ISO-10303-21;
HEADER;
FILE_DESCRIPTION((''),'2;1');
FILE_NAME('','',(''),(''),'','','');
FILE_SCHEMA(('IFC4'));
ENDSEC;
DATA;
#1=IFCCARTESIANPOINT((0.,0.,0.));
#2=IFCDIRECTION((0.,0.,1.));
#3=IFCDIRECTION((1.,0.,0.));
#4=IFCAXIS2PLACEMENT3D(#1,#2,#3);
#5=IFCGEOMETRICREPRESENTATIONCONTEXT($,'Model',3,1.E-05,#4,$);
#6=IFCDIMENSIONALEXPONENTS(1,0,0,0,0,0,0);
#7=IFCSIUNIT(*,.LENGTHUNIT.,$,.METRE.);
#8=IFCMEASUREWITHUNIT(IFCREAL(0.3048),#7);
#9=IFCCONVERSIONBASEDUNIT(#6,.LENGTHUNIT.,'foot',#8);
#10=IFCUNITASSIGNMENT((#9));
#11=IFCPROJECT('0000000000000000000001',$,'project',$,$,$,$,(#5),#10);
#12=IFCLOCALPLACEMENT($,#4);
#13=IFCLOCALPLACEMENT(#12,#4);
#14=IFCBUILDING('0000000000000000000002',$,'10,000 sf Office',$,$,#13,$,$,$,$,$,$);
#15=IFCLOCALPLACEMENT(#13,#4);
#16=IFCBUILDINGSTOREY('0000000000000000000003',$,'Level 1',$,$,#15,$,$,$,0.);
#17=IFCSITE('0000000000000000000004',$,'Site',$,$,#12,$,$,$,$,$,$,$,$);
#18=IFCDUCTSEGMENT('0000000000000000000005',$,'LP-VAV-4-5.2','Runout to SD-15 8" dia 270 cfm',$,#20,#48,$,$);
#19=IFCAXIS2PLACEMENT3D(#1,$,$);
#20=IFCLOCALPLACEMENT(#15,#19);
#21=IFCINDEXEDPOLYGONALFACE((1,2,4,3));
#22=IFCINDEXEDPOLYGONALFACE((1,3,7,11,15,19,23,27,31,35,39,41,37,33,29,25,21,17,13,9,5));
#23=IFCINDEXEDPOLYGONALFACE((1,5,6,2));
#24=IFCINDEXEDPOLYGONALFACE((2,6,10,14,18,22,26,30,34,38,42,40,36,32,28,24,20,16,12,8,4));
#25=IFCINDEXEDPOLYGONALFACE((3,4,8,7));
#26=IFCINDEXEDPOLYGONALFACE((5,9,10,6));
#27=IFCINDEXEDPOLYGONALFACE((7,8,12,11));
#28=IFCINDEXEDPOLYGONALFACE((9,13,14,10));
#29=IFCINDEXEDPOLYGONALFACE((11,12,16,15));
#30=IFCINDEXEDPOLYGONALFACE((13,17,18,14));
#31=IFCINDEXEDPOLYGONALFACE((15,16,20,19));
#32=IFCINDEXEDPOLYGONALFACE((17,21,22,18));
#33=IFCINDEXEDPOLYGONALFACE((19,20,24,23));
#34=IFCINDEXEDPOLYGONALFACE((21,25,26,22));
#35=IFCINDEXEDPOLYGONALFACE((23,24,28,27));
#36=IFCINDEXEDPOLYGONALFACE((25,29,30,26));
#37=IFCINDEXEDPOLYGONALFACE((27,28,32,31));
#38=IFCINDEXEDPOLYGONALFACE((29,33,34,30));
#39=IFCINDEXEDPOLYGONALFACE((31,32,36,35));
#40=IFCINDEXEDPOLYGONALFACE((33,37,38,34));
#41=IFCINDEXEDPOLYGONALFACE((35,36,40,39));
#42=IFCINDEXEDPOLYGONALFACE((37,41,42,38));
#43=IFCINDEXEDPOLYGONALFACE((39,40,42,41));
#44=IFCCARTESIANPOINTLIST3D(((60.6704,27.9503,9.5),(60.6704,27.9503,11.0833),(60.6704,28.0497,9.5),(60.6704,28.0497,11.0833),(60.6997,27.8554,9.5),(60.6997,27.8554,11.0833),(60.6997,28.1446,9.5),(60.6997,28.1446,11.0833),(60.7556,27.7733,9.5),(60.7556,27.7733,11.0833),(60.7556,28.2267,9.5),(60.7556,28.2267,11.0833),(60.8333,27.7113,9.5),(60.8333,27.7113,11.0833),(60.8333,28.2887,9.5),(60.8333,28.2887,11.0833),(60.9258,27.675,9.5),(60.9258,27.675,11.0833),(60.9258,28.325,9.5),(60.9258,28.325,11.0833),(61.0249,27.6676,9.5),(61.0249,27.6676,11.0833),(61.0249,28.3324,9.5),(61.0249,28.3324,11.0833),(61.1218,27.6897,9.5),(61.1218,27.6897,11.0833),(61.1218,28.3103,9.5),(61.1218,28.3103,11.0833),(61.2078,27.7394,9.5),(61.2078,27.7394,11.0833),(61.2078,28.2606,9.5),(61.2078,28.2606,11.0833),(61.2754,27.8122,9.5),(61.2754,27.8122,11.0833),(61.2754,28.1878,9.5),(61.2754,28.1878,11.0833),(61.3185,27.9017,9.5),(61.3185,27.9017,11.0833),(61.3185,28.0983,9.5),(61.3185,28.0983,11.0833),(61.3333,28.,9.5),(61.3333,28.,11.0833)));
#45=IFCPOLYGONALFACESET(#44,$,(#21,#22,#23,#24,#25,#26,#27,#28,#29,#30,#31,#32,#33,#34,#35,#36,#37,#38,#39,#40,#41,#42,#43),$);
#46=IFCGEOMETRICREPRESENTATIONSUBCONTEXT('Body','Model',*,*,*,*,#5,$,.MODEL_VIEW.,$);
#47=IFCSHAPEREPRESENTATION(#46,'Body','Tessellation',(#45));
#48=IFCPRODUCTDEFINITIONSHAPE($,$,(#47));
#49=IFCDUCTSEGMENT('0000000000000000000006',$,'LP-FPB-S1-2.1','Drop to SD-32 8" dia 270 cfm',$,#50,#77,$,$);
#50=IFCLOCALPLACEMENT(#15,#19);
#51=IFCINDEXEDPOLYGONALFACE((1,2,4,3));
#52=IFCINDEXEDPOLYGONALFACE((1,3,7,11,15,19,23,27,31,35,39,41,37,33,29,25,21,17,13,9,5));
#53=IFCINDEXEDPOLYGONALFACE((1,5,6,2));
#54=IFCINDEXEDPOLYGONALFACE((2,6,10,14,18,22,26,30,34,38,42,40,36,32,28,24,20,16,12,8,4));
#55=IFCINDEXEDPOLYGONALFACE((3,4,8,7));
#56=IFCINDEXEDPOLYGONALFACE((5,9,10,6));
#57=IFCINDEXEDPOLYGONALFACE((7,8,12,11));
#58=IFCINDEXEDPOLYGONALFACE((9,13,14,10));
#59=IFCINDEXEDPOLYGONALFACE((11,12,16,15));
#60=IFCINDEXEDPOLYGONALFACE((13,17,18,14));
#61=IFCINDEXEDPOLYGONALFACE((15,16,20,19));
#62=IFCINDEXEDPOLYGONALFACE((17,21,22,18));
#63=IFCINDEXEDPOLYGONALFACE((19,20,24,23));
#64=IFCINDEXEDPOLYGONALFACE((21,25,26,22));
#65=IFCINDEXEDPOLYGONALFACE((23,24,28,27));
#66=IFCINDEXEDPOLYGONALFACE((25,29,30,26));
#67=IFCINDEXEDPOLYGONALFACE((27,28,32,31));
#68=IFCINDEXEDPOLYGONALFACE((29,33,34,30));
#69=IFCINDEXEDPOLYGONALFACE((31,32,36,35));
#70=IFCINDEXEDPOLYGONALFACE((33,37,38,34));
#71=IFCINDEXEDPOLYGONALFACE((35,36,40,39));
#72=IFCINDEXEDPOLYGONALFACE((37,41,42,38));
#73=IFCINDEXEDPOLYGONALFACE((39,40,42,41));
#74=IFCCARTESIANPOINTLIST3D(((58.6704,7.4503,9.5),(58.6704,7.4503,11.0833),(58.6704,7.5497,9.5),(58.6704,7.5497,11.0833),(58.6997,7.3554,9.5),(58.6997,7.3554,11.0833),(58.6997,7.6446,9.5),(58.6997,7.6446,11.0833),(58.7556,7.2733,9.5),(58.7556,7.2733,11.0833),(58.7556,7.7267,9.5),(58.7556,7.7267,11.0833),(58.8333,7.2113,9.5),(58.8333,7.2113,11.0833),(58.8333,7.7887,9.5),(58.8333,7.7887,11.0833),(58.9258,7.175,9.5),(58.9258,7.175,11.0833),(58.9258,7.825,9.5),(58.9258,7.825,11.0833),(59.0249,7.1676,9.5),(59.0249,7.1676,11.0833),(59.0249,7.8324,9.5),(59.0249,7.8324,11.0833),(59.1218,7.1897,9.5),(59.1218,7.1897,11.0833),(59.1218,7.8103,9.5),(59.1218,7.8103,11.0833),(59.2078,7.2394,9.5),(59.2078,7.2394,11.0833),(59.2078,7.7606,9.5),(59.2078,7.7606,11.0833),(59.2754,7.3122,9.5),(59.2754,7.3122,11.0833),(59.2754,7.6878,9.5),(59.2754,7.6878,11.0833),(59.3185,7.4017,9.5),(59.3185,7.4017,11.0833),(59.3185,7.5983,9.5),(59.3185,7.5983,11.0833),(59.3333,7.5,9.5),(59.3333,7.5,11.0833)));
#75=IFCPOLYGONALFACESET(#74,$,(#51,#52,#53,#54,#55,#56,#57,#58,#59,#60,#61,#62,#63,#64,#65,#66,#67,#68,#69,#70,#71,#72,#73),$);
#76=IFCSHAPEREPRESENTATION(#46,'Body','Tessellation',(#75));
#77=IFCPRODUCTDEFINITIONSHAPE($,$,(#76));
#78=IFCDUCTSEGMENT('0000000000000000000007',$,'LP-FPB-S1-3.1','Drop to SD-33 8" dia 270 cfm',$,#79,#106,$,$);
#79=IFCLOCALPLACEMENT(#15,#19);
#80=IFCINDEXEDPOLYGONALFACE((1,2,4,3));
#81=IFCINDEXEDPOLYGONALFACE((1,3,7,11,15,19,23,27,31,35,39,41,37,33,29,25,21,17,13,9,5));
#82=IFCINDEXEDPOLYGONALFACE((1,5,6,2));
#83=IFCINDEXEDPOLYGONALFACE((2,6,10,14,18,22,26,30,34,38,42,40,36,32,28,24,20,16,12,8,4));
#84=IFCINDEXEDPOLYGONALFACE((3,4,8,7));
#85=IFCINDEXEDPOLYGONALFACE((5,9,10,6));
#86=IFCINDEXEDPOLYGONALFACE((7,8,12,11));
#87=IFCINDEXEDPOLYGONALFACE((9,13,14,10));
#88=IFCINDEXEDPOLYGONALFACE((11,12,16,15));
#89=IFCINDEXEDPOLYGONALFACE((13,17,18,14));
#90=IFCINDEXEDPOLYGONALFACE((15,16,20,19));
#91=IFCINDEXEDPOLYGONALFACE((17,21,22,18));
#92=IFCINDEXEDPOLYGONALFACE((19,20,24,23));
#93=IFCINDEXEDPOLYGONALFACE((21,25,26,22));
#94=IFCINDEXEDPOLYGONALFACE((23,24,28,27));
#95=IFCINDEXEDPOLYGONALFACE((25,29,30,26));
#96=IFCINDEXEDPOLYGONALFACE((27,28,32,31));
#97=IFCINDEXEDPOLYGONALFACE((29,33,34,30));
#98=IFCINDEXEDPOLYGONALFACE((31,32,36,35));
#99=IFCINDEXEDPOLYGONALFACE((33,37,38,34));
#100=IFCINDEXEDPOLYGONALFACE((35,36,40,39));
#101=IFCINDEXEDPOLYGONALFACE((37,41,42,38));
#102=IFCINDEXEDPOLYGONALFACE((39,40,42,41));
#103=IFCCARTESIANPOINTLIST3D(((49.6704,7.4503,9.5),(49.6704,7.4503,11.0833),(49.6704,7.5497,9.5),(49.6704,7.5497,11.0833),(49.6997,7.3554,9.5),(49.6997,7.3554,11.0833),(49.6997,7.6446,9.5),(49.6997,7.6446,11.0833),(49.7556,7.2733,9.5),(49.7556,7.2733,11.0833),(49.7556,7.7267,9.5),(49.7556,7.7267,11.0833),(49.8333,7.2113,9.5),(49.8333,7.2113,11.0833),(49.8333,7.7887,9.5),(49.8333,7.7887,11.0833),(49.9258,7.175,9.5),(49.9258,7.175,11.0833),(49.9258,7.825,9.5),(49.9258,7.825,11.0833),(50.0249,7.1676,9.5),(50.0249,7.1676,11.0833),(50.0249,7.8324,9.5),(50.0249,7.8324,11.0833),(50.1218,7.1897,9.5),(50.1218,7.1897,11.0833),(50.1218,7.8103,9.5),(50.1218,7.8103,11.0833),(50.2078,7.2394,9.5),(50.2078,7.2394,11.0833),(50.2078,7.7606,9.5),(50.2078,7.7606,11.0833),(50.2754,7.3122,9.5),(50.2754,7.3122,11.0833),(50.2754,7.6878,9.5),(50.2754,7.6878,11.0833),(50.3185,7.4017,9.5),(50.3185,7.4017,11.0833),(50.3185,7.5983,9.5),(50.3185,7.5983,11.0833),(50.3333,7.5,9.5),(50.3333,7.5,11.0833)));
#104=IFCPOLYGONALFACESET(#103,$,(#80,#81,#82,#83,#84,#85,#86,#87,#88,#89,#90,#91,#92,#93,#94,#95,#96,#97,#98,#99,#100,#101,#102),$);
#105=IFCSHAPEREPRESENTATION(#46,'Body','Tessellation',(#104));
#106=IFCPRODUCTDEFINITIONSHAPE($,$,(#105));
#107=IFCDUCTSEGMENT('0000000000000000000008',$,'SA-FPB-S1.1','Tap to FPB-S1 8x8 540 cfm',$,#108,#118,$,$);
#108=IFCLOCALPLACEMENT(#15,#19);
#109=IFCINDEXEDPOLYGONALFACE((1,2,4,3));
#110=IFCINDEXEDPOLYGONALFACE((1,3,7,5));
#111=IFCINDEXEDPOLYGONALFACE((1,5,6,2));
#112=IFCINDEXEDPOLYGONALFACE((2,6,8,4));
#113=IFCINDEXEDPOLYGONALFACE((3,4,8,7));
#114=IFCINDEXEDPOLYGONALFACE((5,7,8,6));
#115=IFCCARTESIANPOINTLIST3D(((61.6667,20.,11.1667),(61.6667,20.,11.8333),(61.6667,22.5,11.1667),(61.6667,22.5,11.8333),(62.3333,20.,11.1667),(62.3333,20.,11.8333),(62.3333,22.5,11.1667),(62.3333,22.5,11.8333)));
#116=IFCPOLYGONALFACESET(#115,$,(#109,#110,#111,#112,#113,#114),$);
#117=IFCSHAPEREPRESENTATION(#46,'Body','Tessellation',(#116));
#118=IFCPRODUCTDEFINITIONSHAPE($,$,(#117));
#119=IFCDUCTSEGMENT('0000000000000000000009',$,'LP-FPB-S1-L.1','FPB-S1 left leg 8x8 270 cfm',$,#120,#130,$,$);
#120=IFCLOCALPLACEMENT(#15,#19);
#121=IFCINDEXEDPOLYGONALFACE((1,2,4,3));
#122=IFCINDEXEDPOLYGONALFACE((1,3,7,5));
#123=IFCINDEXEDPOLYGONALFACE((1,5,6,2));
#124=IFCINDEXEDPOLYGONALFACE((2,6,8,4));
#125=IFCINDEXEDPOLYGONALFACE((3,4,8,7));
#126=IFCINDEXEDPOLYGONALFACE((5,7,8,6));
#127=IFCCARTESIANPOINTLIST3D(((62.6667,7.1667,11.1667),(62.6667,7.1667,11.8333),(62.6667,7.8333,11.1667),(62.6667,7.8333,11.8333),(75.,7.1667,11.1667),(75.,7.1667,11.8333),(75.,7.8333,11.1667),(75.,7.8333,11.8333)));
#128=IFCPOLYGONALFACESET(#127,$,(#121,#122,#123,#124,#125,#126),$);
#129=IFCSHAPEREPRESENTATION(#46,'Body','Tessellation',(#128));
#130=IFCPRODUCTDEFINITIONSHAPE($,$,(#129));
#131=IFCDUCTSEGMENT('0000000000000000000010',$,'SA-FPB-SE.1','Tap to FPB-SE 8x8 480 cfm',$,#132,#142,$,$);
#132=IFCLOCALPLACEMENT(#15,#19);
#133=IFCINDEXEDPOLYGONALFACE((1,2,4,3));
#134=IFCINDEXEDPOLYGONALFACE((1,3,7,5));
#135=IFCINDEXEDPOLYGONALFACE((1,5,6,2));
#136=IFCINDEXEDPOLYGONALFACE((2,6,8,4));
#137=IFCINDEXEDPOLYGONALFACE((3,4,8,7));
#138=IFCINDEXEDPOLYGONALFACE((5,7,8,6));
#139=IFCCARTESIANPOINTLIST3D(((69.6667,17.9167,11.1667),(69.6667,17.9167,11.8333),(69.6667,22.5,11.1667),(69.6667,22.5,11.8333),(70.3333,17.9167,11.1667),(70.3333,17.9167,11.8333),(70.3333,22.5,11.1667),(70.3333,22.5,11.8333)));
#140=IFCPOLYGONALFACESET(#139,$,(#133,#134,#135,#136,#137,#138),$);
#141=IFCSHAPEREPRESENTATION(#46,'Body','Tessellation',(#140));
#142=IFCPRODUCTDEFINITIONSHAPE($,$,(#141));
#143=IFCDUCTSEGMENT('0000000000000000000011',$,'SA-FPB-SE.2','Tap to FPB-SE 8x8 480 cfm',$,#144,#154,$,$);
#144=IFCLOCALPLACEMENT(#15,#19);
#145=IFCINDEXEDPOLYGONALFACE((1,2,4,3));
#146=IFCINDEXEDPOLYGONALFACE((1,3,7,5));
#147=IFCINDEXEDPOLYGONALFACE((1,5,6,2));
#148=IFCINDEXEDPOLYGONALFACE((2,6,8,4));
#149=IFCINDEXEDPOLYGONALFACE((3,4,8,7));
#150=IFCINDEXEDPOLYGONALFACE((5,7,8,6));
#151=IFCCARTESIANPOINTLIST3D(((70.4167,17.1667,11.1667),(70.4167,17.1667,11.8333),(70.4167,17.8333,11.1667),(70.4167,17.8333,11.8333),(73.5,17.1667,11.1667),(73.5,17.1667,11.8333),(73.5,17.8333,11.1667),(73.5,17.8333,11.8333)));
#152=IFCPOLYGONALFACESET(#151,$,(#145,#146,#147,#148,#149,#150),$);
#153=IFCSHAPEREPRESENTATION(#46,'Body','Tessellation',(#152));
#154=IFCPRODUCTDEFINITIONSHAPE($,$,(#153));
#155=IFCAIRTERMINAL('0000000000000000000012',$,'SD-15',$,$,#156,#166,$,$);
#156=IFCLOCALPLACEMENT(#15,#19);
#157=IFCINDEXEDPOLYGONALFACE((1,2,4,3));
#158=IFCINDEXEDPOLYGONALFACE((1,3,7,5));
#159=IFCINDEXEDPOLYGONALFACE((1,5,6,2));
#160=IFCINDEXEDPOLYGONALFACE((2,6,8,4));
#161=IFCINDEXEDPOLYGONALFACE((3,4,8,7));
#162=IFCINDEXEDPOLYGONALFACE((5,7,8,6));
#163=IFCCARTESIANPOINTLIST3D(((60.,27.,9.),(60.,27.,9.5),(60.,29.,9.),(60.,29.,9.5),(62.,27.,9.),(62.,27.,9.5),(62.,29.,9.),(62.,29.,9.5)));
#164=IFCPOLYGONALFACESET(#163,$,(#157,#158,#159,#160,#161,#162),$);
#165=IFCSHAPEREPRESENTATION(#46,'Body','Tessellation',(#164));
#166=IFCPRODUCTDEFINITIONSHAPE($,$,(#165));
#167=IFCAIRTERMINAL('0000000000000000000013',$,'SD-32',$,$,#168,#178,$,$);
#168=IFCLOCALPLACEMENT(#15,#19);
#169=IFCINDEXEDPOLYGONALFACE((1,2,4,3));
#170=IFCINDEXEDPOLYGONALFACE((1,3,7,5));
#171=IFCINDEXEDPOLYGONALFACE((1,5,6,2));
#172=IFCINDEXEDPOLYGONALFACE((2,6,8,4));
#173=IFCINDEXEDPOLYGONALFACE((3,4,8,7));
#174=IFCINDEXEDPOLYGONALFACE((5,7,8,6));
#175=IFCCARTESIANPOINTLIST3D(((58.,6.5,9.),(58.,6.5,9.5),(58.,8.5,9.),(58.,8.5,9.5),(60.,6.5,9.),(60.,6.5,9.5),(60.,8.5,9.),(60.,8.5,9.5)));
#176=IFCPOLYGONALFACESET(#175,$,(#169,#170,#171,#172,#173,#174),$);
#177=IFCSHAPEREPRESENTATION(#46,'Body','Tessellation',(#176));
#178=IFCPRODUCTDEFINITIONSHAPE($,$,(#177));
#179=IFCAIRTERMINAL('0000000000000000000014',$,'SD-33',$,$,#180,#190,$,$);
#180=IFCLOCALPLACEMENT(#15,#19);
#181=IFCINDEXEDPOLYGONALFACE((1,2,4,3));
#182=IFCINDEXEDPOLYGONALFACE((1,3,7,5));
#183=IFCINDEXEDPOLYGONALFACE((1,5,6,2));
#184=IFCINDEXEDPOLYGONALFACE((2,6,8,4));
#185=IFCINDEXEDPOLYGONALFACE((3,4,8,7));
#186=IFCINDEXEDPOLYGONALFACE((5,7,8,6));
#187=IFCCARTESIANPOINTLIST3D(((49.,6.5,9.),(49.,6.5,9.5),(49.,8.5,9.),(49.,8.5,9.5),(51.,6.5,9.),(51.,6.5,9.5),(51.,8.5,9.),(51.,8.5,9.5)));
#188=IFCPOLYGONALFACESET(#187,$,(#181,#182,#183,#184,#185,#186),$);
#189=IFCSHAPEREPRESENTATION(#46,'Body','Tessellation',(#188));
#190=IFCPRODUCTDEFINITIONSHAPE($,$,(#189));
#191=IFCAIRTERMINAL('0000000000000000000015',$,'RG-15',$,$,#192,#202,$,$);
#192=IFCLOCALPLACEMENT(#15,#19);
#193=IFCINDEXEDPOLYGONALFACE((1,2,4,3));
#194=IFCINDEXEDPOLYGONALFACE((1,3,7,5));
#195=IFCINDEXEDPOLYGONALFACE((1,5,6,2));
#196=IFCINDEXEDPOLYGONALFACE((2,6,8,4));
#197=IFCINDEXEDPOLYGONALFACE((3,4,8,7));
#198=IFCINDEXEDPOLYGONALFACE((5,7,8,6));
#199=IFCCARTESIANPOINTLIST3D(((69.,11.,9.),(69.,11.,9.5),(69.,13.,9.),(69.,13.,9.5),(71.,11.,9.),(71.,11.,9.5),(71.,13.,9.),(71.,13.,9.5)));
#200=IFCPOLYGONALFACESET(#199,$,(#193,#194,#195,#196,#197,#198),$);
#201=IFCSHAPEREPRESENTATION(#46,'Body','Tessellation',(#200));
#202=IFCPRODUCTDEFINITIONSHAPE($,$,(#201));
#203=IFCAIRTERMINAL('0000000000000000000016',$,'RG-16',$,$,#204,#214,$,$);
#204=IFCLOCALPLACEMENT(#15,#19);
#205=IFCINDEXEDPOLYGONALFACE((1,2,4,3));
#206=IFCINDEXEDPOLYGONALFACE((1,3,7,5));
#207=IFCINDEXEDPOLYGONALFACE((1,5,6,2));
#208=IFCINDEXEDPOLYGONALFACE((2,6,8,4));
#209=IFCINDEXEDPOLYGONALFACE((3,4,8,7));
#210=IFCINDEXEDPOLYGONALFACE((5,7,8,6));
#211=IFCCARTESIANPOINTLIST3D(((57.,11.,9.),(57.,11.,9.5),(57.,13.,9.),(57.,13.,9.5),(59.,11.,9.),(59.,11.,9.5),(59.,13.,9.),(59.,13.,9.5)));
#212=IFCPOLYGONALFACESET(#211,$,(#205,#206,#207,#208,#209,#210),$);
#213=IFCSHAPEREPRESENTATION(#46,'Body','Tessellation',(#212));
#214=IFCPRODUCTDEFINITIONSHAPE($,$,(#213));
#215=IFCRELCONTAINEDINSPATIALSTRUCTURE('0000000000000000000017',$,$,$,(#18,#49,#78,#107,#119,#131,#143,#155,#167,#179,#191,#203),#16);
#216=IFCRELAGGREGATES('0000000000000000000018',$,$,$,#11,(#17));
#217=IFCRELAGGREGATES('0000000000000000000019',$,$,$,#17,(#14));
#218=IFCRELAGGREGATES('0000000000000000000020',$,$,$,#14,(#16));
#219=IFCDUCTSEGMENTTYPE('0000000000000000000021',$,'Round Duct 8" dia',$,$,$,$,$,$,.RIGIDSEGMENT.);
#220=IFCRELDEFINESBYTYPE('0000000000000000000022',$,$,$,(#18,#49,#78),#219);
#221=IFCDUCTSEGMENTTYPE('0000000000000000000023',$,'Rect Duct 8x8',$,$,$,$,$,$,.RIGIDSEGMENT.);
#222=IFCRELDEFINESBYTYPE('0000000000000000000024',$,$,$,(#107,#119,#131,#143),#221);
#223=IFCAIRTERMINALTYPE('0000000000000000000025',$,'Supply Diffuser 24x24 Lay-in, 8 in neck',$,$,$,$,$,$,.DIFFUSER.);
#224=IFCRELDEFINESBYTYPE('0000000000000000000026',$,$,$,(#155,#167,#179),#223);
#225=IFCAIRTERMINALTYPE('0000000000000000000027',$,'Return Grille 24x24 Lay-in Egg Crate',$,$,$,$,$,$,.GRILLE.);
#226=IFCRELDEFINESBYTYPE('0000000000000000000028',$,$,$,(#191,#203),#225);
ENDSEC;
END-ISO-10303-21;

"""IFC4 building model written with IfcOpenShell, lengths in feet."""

from ifc_helpers import new_model, entity, si_unit, converted_unit, frame, origin_with_axes, place, context, subcontext, project, spatial, rectangle, circle, extrude, type_object, element, save


model = new_model("IFC4")

# Units and contexts
model_context = context("Model", 3, precision=1e-05, world=origin_with_axes())
body_context = subcontext(model_context, "Body", "Model", "MODEL_VIEW")
ifc_project = project(units=[converted_unit("LENGTHUNIT", "foot", entity("IfcReal", 0.3048), si_unit("LENGTHUNIT", "METRE"), dimensions=[1, 0, 0, 0, 0, 0, 0])], contexts=[model_context])

# Site, building, storey
site_placement = place(None, origin_with_axes())
site = spatial("IfcSite", under=ifc_project, at=site_placement, Name="Site")
building_placement = place(site_placement, origin_with_axes())
building = spatial("IfcBuilding", under=site, at=building_placement, Name="10,000 sf Office")
storey_placement = place(building_placement, origin_with_axes())
storey = spatial("IfcBuildingStorey", under=building, at=storey_placement, Name="Level 1", Elevation=0.0)

# Duct segments
duct_segment_type_1 = type_object("IfcDuctSegmentType", Name="Round Duct 8\" dia", PredefinedType="RIGIDSEGMENT")
for number, where, z_axis, x_axis, name, description in (
    (1, (61.0, 28.0, 11.0833), (0.0, 0.0, -1.0), (1.0, 0.0, 0.0), "LP-VAV-4-5.2", "Runout to SD-15 8\" dia 270 cfm"),
    (2, (59.0, 7.5, 11.0833), (0.0, 0.0, -1.0), (1.0, 0.0, 0.0), "LP-FPB-S1-2.1", "Drop to SD-32 8\" dia 270 cfm"),
    (3, (50.0, 7.5, 11.0833), (0.0, 0.0, -1.0), (1.0, 0.0, 0.0), "LP-FPB-S1-3.1", "Drop to SD-33 8\" dia 270 cfm"),
):
    element("IfcDuctSegment", number, at=place(storey_placement, frame(where, z_axis=z_axis, x_axis=x_axis)), inside=storey, type_object=duct_segment_type_1, Name=name, Description=description, context=body_context, shape_type="SweptSolid", body=[
        extrude(circle(Radius=0.3333), None, (0.0, 0.0, 1.0), 1.5833),
    ])
duct_segment_type_2 = type_object("IfcDuctSegmentType", Name="Rect Duct 8x8", PredefinedType="RIGIDSEGMENT")
duct_segment_1_placement = place(storey_placement, frame((62.0, 22.5, 11.5), z_axis=(0.0, -1.0, 0.0), x_axis=(1.0, 0.0, 0.0)))
element("IfcDuctSegment", 4, at=duct_segment_1_placement, inside=storey, type_object=duct_segment_type_2, Name="SA-FPB-S1.1", Description="Tap to FPB-S1 8x8 540 cfm", context=body_context, shape_type="SweptSolid", body=[
    extrude(rectangle(XDim=0.6667, YDim=0.6667), None, (0.0, 0.0, 1.0), 2.5),
])
duct_segment_2_placement = place(storey_placement, frame((62.6667, 7.5, 11.5), z_axis=(1.0, 0.0, 0.0), x_axis=(0.0, 1.0, 0.0)))
element("IfcDuctSegment", 5, at=duct_segment_2_placement, inside=storey, type_object=duct_segment_type_2, Name="LP-FPB-S1-L.1", Description="FPB-S1 left leg 8x8 270 cfm", context=body_context, shape_type="SweptSolid", body=[
    extrude(rectangle(XDim=0.6667, YDim=0.6667), None, (0.0, 0.0, 1.0), 12.3333),
])
duct_segment_3_placement = place(storey_placement, frame((70.0, 22.5, 11.5), z_axis=(0.0, -1.0, 0.0), x_axis=(1.0, 0.0, 0.0)))
element("IfcDuctSegment", 6, at=duct_segment_3_placement, inside=storey, type_object=duct_segment_type_2, Name="SA-FPB-SE.1", Description="Tap to FPB-SE 8x8 480 cfm", context=body_context, shape_type="SweptSolid", body=[
    extrude(rectangle(XDim=0.6667, YDim=0.6667), None, (0.0, 0.0, 1.0), 4.5833),
])
duct_segment_4_placement = place(storey_placement, frame((70.4167, 17.5, 11.5), z_axis=(1.0, 0.0, 0.0), x_axis=(0.0, 1.0, 0.0)))
element("IfcDuctSegment", 7, at=duct_segment_4_placement, inside=storey, type_object=duct_segment_type_2, Name="SA-FPB-SE.2", Description="Tap to FPB-SE 8x8 480 cfm", context=body_context, shape_type="SweptSolid", body=[
    extrude(rectangle(XDim=0.6667, YDim=0.6667), None, (0.0, 0.0, 1.0), 3.0833),
])

# Air terminals
air_terminal_type_1 = type_object("IfcAirTerminalType", Name="Supply Diffuser 24x24 Lay-in, 8 in neck", PredefinedType="DIFFUSER")
for number, where, z_axis, x_axis, name in (
    (8, (61.0, 28.0, 9.0), (0.0, 0.0, 1.0), (1.0, 0.0, 0.0), "SD-15"),
    (9, (59.0, 7.5, 9.0), (0.0, 0.0, 1.0), (1.0, 0.0, 0.0), "SD-32"),
    (10, (50.0, 7.5, 9.0), (0.0, 0.0, 1.0), (1.0, 0.0, 0.0), "SD-33"),
):
    element("IfcAirTerminal", number, at=place(storey_placement, frame(where, z_axis=z_axis, x_axis=x_axis)), inside=storey, type_object=air_terminal_type_1, Name=name, context=body_context, shape_type="SweptSolid", body=[
        extrude(rectangle(XDim=2.0, YDim=2.0), None, (0.0, 0.0, 1.0), 0.5),
    ])
air_terminal_type_2 = type_object("IfcAirTerminalType", Name="Return Grille 24x24 Lay-in Egg Crate", PredefinedType="GRILLE")
for number, where, z_axis, x_axis, name in (
    (11, (70.0, 12.0, 9.0), (0.0, 0.0, 1.0), (1.0, 0.0, 0.0), "RG-15"),
    (12, (58.0, 12.0, 9.0), (0.0, 0.0, 1.0), (1.0, 0.0, 0.0), "RG-16"),
):
    element("IfcAirTerminal", number, at=place(storey_placement, frame(where, z_axis=z_axis, x_axis=x_axis)), inside=storey, type_object=air_terminal_type_2, Name=name, context=body_context, shape_type="SweptSolid", body=[
        extrude(rectangle(XDim=2.0, YDim=2.0), None, (0.0, 0.0, 1.0), 0.5),
    ])

save(model, "model.ifc")
